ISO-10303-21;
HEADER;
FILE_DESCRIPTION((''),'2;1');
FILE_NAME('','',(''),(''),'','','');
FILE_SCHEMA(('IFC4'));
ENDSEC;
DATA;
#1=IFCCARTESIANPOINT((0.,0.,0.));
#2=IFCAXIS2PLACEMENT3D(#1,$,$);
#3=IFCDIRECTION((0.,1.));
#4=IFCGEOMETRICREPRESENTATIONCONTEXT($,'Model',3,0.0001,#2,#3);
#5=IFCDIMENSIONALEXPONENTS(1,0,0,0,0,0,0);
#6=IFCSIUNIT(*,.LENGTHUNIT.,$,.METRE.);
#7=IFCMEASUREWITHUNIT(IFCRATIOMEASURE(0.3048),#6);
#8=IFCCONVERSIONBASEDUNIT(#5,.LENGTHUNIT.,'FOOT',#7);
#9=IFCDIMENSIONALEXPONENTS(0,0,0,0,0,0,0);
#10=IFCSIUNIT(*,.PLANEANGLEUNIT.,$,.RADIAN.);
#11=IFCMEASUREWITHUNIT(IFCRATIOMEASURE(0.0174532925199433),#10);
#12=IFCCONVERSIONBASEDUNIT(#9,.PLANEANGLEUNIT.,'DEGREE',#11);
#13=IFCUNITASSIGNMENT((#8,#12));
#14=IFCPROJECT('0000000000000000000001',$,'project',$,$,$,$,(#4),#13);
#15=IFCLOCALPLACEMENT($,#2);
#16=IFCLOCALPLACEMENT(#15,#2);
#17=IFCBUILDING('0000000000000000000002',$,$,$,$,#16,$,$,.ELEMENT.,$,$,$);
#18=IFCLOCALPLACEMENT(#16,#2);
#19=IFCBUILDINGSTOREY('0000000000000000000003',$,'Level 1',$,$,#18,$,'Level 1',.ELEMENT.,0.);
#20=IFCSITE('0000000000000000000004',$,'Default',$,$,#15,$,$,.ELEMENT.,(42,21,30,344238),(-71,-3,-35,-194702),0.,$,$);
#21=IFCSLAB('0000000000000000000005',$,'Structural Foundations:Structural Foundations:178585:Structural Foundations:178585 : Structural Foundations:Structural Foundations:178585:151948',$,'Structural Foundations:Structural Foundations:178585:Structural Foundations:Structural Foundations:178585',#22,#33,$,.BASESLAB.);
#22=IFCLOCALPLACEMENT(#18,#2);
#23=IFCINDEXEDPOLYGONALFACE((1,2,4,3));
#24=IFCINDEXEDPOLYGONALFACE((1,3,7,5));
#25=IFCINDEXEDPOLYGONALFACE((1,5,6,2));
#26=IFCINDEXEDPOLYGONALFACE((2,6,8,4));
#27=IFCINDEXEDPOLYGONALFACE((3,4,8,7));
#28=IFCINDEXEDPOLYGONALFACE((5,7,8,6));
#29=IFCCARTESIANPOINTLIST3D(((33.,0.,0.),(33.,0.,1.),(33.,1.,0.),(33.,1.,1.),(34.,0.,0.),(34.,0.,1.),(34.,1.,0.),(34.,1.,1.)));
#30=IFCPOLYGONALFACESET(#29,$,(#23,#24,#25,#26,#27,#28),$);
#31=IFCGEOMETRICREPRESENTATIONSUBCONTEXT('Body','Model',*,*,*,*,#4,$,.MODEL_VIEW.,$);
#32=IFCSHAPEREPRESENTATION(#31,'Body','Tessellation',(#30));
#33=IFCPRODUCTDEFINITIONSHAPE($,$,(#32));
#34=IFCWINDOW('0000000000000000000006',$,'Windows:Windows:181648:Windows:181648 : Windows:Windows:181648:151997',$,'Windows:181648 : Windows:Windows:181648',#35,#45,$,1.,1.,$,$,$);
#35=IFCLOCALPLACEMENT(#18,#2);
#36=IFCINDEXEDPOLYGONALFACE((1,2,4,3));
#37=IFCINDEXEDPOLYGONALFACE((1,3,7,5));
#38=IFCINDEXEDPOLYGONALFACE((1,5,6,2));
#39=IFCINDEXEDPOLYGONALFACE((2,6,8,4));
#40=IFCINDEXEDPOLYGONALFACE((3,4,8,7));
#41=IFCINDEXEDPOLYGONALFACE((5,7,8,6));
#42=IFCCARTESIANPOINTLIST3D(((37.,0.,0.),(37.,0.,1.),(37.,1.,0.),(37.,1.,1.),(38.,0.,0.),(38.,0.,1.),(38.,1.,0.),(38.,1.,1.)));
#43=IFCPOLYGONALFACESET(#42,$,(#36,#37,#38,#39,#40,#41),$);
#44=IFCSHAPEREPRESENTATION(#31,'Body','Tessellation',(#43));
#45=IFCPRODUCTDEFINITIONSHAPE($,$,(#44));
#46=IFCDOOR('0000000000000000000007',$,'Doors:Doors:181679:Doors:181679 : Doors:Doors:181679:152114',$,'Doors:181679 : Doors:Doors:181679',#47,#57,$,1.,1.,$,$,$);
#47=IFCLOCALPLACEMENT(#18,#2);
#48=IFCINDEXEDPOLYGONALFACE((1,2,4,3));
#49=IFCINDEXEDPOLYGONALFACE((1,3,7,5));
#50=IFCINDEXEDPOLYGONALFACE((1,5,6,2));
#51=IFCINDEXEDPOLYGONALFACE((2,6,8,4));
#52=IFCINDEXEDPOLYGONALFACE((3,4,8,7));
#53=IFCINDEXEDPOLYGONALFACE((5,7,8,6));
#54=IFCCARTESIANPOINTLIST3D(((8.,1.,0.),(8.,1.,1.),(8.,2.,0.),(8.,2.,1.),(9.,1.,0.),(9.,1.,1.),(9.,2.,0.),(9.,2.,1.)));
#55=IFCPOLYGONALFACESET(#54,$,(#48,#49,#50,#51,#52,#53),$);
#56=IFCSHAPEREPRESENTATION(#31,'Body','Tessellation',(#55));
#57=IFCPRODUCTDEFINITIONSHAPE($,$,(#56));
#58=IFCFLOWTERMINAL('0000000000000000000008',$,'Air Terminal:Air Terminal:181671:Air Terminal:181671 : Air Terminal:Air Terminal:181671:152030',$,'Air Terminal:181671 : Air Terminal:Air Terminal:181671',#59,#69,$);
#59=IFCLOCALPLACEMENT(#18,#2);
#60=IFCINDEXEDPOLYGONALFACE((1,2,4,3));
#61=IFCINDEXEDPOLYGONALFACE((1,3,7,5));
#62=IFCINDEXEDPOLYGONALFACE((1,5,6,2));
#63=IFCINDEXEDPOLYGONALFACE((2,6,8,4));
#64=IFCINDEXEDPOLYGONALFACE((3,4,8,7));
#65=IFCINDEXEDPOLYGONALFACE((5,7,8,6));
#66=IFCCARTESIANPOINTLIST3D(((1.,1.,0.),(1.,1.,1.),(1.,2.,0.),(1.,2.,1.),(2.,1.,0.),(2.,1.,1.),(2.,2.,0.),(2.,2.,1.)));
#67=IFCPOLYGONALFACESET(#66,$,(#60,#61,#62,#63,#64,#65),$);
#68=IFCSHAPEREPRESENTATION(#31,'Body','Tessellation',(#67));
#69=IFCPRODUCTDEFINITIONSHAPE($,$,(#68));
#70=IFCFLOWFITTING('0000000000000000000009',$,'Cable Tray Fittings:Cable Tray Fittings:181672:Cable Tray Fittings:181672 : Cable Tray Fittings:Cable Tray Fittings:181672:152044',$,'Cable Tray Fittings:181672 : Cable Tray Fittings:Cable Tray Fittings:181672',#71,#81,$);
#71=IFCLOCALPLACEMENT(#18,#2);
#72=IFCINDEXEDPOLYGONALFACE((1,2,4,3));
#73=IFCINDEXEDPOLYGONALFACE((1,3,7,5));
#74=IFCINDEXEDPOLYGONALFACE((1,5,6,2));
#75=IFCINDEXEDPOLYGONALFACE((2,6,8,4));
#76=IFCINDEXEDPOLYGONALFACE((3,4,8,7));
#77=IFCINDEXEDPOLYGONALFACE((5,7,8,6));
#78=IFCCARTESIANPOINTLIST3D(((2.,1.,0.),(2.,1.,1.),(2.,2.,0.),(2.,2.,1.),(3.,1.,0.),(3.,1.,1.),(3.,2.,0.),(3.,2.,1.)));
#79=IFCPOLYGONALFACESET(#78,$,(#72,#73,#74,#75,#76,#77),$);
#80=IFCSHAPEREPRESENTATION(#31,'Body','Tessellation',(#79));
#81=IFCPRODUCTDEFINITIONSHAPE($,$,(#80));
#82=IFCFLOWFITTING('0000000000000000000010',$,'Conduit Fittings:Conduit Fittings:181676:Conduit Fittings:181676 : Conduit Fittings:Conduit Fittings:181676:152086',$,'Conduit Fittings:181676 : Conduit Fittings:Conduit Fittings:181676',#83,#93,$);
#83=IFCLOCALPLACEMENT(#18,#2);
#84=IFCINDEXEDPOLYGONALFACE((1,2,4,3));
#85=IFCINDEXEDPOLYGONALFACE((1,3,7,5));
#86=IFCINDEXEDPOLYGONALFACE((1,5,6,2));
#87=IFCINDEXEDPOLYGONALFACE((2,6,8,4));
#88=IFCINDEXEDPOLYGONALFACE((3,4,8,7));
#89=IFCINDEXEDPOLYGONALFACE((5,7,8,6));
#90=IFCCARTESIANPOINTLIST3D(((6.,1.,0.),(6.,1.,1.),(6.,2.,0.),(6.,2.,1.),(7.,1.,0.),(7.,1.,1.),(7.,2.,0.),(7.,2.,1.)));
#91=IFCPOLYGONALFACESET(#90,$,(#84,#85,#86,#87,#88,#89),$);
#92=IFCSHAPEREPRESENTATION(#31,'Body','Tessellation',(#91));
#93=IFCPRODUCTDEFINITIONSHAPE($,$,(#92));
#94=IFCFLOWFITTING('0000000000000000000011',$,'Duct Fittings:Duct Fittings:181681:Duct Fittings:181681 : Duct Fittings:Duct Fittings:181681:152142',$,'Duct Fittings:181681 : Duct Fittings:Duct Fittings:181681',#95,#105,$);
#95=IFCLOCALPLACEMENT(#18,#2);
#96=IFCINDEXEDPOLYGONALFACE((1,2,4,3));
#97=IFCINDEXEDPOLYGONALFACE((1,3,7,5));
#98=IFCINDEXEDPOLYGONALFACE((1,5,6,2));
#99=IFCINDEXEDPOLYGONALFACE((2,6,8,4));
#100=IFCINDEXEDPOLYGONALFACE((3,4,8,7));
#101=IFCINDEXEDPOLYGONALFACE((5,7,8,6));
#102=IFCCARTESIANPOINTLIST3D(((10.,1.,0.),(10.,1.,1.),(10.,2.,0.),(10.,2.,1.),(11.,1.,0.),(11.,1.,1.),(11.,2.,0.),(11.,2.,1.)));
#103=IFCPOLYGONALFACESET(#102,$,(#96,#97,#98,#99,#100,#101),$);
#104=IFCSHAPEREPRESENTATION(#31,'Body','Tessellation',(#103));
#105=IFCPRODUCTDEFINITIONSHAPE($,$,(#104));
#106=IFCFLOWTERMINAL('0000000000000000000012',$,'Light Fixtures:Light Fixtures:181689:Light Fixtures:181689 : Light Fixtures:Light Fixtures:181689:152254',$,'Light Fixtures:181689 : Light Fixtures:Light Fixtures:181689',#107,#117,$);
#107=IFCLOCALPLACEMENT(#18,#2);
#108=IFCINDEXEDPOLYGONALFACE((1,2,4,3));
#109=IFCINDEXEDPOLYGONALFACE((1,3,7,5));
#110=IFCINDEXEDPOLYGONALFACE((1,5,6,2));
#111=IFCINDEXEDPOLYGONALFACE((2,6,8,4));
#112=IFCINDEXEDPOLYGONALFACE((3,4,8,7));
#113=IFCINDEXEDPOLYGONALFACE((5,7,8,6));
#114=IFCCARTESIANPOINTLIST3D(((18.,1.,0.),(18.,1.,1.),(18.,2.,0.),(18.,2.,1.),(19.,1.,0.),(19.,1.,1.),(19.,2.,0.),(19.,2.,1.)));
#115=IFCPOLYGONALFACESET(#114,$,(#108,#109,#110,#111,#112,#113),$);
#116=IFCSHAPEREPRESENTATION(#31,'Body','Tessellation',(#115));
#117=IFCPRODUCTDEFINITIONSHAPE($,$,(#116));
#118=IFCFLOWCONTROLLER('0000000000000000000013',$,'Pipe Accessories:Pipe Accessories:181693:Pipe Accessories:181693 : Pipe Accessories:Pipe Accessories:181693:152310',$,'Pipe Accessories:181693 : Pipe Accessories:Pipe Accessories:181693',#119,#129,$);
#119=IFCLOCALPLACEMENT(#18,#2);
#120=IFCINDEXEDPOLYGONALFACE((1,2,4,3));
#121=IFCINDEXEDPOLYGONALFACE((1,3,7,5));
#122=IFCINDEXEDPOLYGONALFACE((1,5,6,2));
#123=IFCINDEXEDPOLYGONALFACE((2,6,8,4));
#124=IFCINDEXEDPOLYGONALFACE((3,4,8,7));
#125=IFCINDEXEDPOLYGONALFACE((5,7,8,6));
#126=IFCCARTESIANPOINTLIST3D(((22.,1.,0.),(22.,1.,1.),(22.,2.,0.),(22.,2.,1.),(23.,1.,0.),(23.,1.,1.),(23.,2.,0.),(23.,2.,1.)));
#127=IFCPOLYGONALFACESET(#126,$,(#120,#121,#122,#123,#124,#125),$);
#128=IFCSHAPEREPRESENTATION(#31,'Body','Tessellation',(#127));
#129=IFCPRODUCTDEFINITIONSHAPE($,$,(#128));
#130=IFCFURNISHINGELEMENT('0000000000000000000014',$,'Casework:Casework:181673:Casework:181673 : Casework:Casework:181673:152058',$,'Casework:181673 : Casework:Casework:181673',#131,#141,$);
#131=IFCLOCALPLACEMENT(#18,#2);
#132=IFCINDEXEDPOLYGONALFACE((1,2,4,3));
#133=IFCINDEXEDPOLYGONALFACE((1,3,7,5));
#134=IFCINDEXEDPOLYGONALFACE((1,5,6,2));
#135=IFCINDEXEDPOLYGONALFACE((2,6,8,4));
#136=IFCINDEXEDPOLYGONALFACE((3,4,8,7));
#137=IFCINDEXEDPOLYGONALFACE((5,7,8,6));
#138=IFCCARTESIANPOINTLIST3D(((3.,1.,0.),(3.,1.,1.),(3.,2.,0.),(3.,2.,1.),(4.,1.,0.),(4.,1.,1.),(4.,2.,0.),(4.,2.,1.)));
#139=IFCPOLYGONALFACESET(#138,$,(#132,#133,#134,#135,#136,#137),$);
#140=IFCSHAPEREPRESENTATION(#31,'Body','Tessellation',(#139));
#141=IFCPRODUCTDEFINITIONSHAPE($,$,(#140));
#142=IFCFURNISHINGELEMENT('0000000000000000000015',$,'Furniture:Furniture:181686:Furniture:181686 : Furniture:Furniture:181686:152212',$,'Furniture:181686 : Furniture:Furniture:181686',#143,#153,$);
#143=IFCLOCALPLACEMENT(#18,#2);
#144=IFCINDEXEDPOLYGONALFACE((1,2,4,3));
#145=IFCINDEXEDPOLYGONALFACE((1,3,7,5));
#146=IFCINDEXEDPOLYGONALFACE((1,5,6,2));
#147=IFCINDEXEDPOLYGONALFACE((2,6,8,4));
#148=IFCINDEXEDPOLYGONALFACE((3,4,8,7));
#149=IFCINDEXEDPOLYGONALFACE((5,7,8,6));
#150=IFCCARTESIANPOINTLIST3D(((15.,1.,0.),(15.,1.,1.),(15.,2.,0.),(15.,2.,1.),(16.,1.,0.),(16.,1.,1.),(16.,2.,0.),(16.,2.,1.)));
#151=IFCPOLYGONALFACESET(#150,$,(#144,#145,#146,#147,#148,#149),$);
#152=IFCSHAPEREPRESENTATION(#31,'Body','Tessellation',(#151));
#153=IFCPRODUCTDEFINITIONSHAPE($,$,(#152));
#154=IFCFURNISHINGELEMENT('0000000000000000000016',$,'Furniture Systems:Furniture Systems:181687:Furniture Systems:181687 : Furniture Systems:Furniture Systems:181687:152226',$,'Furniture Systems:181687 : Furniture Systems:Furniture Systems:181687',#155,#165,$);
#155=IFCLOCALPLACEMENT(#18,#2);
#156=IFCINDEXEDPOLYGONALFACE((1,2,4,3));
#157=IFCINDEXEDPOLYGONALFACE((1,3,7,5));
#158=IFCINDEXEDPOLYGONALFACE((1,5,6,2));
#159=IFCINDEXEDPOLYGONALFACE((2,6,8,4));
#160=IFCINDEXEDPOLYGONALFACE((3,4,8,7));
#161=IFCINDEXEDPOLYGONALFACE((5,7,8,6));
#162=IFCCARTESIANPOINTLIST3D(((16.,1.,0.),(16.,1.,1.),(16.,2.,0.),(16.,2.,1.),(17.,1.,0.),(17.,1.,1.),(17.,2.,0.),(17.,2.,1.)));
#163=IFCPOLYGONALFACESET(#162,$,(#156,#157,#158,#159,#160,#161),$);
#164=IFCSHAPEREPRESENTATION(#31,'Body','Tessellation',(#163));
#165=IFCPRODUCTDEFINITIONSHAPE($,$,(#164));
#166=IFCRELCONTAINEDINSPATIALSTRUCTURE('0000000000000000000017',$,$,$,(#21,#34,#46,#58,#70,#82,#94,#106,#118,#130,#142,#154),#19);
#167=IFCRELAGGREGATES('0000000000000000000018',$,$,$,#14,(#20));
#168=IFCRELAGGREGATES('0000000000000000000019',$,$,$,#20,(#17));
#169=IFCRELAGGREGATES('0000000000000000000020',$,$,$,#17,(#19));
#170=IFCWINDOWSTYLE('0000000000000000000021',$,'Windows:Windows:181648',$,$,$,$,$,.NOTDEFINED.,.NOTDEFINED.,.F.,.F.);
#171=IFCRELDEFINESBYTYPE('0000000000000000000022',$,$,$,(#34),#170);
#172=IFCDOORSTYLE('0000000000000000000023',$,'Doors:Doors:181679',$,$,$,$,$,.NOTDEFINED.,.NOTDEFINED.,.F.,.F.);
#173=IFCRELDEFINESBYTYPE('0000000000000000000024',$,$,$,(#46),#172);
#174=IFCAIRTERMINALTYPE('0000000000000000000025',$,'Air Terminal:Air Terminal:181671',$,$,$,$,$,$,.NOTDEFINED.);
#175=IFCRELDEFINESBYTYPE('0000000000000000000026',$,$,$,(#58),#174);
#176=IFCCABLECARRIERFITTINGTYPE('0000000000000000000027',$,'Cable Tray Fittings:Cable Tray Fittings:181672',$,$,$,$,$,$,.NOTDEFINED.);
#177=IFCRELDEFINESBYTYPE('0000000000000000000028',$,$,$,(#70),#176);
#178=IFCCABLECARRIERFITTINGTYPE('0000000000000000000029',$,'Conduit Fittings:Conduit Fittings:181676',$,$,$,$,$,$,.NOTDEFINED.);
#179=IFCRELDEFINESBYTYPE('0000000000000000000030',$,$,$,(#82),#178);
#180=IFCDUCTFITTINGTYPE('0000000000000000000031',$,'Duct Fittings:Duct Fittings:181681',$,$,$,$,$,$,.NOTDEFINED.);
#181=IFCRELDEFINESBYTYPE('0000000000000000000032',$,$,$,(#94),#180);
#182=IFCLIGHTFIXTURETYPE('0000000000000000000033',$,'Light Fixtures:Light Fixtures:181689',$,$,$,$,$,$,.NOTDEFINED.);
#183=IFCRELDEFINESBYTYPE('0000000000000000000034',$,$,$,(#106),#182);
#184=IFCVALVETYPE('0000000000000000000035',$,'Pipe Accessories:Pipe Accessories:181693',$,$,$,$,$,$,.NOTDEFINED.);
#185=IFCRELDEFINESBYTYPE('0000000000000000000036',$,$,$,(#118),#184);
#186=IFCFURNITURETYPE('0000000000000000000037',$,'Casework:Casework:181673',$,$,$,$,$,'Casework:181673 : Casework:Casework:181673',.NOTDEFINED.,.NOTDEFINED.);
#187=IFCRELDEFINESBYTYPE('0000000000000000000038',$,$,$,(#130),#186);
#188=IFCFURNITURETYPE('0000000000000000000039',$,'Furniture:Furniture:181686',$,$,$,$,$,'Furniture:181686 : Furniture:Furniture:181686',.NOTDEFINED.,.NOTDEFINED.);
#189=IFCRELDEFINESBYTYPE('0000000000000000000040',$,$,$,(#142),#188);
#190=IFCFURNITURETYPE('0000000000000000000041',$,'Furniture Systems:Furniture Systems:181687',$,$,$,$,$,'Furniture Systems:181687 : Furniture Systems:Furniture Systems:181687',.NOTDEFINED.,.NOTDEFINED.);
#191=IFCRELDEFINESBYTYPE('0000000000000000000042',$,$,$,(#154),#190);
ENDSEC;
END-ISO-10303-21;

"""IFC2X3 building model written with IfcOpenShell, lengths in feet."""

from ifc_helpers import new_model, entity, si_unit, converted_unit, direction, frame, frame_2d, origin, origin_2d_with_axis, place, context, subcontext, project, spatial, rectangle, extrude, source, transform, mapped, type_object, type_shapes, element, save


model = new_model("IFC2X3")

# Units and contexts
model_context = context("Model", 3, precision=0.0001, world=origin(), true_north=direction((0.0, 1.0)))
body_context = subcontext(model_context, "Body", "Model", "MODEL_VIEW")
ifc_project = project(units=[converted_unit("LENGTHUNIT", "FOOT", entity("IfcRatioMeasure", 0.3048), si_unit("LENGTHUNIT", "METRE"), dimensions=[1, 0, 0, 0, 0, 0, 0]), converted_unit("PLANEANGLEUNIT", "DEGREE", entity("IfcRatioMeasure", 0.0174532925199433), si_unit("PLANEANGLEUNIT", "RADIAN"), dimensions=[0, 0, 0, 0, 0, 0, 0])], contexts=[model_context])

# Site, building, storey
site_placement = place(None, origin())
site = spatial("IfcSite", under=ifc_project, at=site_placement, Name="Default", CompositionType="ELEMENT", RefLatitude=(42, 21, 30, 344238), RefLongitude=(-71, -3, -35, -194702), RefElevation=0.0)
building_placement = place(site_placement, origin())
building = spatial("IfcBuilding", under=site, at=building_placement, CompositionType="ELEMENT")
storey_placement = place(building_placement, origin())
storey = spatial("IfcBuildingStorey", under=building, at=storey_placement, Name="Level 1", LongName="Level 1", CompositionType="ELEMENT", Elevation=0.0)

# Slab
slab_placement = place(storey_placement, origin())
element("IfcSlab", 1, at=slab_placement, inside=storey, Name="Structural Foundations:Structural Foundations:178585:Structural Foundations:178585 : Structural Foundations:Structural Foundations:178585:151948", ObjectType="Structural Foundations:Structural Foundations:178585:Structural Foundations:Structural Foundations:178585", PredefinedType="BASESLAB", context=body_context, shape_type="SweptSolid", body=[
    extrude(rectangle(XDim=1.0, YDim=1.0, at=origin_2d_with_axis()), frame((33.5, 0.5, 0.0), z_axis=(0.0, 0.0, 1.0), x_axis=(-1.0, 0.0, 0.0)), (0.0, 0.0, 1.0), 1.0),
])

# Window
window_style = type_object("IfcWindowStyle", Name="Windows:Windows:181648", ConstructionType="NOTDEFINED", OperationType="NOTDEFINED", ParameterTakesPrecedence=False, Sizeable=False)
shared_shape_1 = source(origin(), body_context, "Body", "SweptSolid", [
    extrude(rectangle(XDim=1.0, YDim=1.0, at=origin_2d_with_axis()), frame((37.5, 0.5, 0.0), z_axis=(0.0, 0.0, 1.0), x_axis=(-1.0, 0.0, 0.0)), (0.0, 0.0, 1.0), 1.0),
])
type_shapes(window_style, [shared_shape_1])
window_placement = place(storey_placement, origin())
element("IfcWindow", 2, at=window_placement, inside=storey, type_object=window_style, Name="Windows:Windows:181648:Windows:181648 : Windows:Windows:181648:151997", ObjectType="Windows:181648 : Windows:Windows:181648", OverallHeight=1.0, OverallWidth=1.0, context=body_context, shape_type="MappedRepresentation", body=[
    mapped(shared_shape_1, transform((0.0, 0.0, 0.0), scale=1.0)),
])

# Door
door_style = type_object("IfcDoorStyle", Name="Doors:Doors:181679", ConstructionType="NOTDEFINED", OperationType="NOTDEFINED", ParameterTakesPrecedence=False, Sizeable=False)
shared_shape_2 = source(origin(), body_context, "Body", "SweptSolid", [
    extrude(rectangle(XDim=1.0, YDim=1.0, at=frame_2d((0.0, 0.0), x_axis=(1.0, 0.0))), frame((8.5, 1.5, 0.0), z_axis=(0.0, 0.0, 1.0), x_axis=(-1.0, 0.0, 0.0)), (0.0, 0.0, 1.0), 1.0),
])
type_shapes(door_style, [shared_shape_2])
door_placement = place(storey_placement, origin())
element("IfcDoor", 3, at=door_placement, inside=storey, type_object=door_style, Name="Doors:Doors:181679:Doors:181679 : Doors:Doors:181679:152114", ObjectType="Doors:181679 : Doors:Doors:181679", OverallHeight=1.0, OverallWidth=1.0, context=body_context, shape_type="MappedRepresentation", body=[
    mapped(shared_shape_2, transform((0.0, 0.0, 0.0), scale=1.0)),
])

# Flow terminal
air_terminal_type = type_object("IfcAirTerminalType", Name="Air Terminal:Air Terminal:181671", PredefinedType="NOTDEFINED")
shared_shape_3 = source(origin(), body_context, "Body", "SweptSolid", [
    extrude(rectangle(XDim=1.0, YDim=1.0, at=frame_2d((0.0, 0.0), x_axis=(1.0, 0.0))), frame((1.5, 1.5, 0.0), z_axis=(0.0, 0.0, 1.0), x_axis=(-1.0, 0.0, 0.0)), (0.0, 0.0, 1.0), 1.0),
])
type_shapes(air_terminal_type, [shared_shape_3])
flow_terminal_1_placement = place(storey_placement, origin())
element("IfcFlowTerminal", 4, at=flow_terminal_1_placement, inside=storey, type_object=air_terminal_type, Name="Air Terminal:Air Terminal:181671:Air Terminal:181671 : Air Terminal:Air Terminal:181671:152030", ObjectType="Air Terminal:181671 : Air Terminal:Air Terminal:181671", context=body_context, shape_type="MappedRepresentation", body=[
    mapped(shared_shape_3, transform((0.0, 0.0, 0.0), scale=1.0)),
])

# Flow fittings
cable_carrier_fitting_type_1 = type_object("IfcCableCarrierFittingType", Name="Cable Tray Fittings:Cable Tray Fittings:181672", PredefinedType="NOTDEFINED")
shared_shape_4 = source(origin(), body_context, "Body", "SweptSolid", [
    extrude(rectangle(XDim=1.0, YDim=1.0, at=frame_2d((0.0, 0.0), x_axis=(1.0, 0.0))), frame((2.5, 1.5, 0.0), z_axis=(0.0, 0.0, 1.0), x_axis=(-1.0, 0.0, 0.0)), (0.0, 0.0, 1.0), 1.0),
])
type_shapes(cable_carrier_fitting_type_1, [shared_shape_4])
flow_fitting_1_placement = place(storey_placement, origin())
element("IfcFlowFitting", 5, at=flow_fitting_1_placement, inside=storey, type_object=cable_carrier_fitting_type_1, Name="Cable Tray Fittings:Cable Tray Fittings:181672:Cable Tray Fittings:181672 : Cable Tray Fittings:Cable Tray Fittings:181672:152044", ObjectType="Cable Tray Fittings:181672 : Cable Tray Fittings:Cable Tray Fittings:181672", context=body_context, shape_type="MappedRepresentation", body=[
    mapped(shared_shape_4, transform((0.0, 0.0, 0.0), scale=1.0)),
])
cable_carrier_fitting_type_2 = type_object("IfcCableCarrierFittingType", Name="Conduit Fittings:Conduit Fittings:181676", PredefinedType="NOTDEFINED")
shared_shape_5 = source(origin(), body_context, "Body", "SweptSolid", [
    extrude(rectangle(XDim=1.0, YDim=1.0, at=frame_2d((0.0, 0.0), x_axis=(1.0, 0.0))), frame((6.5, 1.5, 0.0), z_axis=(0.0, 0.0, 1.0), x_axis=(-1.0, 0.0, 0.0)), (0.0, 0.0, 1.0), 1.0),
])
type_shapes(cable_carrier_fitting_type_2, [shared_shape_5])
flow_fitting_2_placement = place(storey_placement, origin())
element("IfcFlowFitting", 6, at=flow_fitting_2_placement, inside=storey, type_object=cable_carrier_fitting_type_2, Name="Conduit Fittings:Conduit Fittings:181676:Conduit Fittings:181676 : Conduit Fittings:Conduit Fittings:181676:152086", ObjectType="Conduit Fittings:181676 : Conduit Fittings:Conduit Fittings:181676", context=body_context, shape_type="MappedRepresentation", body=[
    mapped(shared_shape_5, transform((0.0, 0.0, 0.0), scale=1.0)),
])
duct_fitting_type = type_object("IfcDuctFittingType", Name="Duct Fittings:Duct Fittings:181681", PredefinedType="NOTDEFINED")
shared_shape_6 = source(origin(), body_context, "Body", "SweptSolid", [
    extrude(rectangle(XDim=1.0, YDim=1.0, at=frame_2d((0.0, 0.0), x_axis=(1.0, 0.0))), frame((10.5, 1.5, 0.0), z_axis=(0.0, 0.0, 1.0), x_axis=(-1.0, 0.0, 0.0)), (0.0, 0.0, 1.0), 1.0),
])
type_shapes(duct_fitting_type, [shared_shape_6])
flow_fitting_3_placement = place(storey_placement, origin())
element("IfcFlowFitting", 7, at=flow_fitting_3_placement, inside=storey, type_object=duct_fitting_type, Name="Duct Fittings:Duct Fittings:181681:Duct Fittings:181681 : Duct Fittings:Duct Fittings:181681:152142", ObjectType="Duct Fittings:181681 : Duct Fittings:Duct Fittings:181681", context=body_context, shape_type="MappedRepresentation", body=[
    mapped(shared_shape_6, transform((0.0, 0.0, 0.0), scale=1.0)),
])

# Flow terminal
light_fixture_type = type_object("IfcLightFixtureType", Name="Light Fixtures:Light Fixtures:181689", PredefinedType="NOTDEFINED")
shared_shape_7 = source(origin(), body_context, "Body", "SweptSolid", [
    extrude(rectangle(XDim=1.0, YDim=1.0, at=frame_2d((0.0, 0.0), x_axis=(1.0, 0.0))), frame((18.5, 1.5, 0.0), z_axis=(0.0, 0.0, 1.0), x_axis=(-1.0, 0.0, 0.0)), (0.0, 0.0, 1.0), 1.0),
])
type_shapes(light_fixture_type, [shared_shape_7])
flow_terminal_2_placement = place(storey_placement, origin())
element("IfcFlowTerminal", 8, at=flow_terminal_2_placement, inside=storey, type_object=light_fixture_type, Name="Light Fixtures:Light Fixtures:181689:Light Fixtures:181689 : Light Fixtures:Light Fixtures:181689:152254", ObjectType="Light Fixtures:181689 : Light Fixtures:Light Fixtures:181689", context=body_context, shape_type="MappedRepresentation", body=[
    mapped(shared_shape_7, transform((0.0, 0.0, 0.0), scale=1.0)),
])

# Flow controller
valve_type = type_object("IfcValveType", Name="Pipe Accessories:Pipe Accessories:181693", PredefinedType="NOTDEFINED")
shared_shape_8 = source(origin(), body_context, "Body", "SweptSolid", [
    extrude(rectangle(XDim=1.0, YDim=1.0, at=frame_2d((0.0, 0.0), x_axis=(1.0, 0.0))), frame((22.5, 1.5, 0.0), z_axis=(0.0, 0.0, 1.0), x_axis=(-1.0, 0.0, 0.0)), (0.0, 0.0, 1.0), 1.0),
])
type_shapes(valve_type, [shared_shape_8])
flow_controller_placement = place(storey_placement, origin())
element("IfcFlowController", 9, at=flow_controller_placement, inside=storey, type_object=valve_type, Name="Pipe Accessories:Pipe Accessories:181693:Pipe Accessories:181693 : Pipe Accessories:Pipe Accessories:181693:152310", ObjectType="Pipe Accessories:181693 : Pipe Accessories:Pipe Accessories:181693", context=body_context, shape_type="MappedRepresentation", body=[
    mapped(shared_shape_8, transform((0.0, 0.0, 0.0), scale=1.0)),
])

# Furnishing elements
furniture_type_1 = type_object("IfcFurnitureType", Name="Casework:Casework:181673", ElementType="Casework:181673 : Casework:Casework:181673")
shared_shape_9 = source(origin(), body_context, "Body", "SweptSolid", [
    extrude(rectangle(XDim=1.0, YDim=1.0, at=frame_2d((0.0, 0.0), x_axis=(1.0, 0.0))), frame((3.5, 1.5, 0.0), z_axis=(0.0, 0.0, 1.0), x_axis=(-1.0, 0.0, 0.0)), (0.0, 0.0, 1.0), 1.0),
])
type_shapes(furniture_type_1, [shared_shape_9])
furnishing_1_placement = place(storey_placement, origin())
element("IfcFurnishingElement", 10, at=furnishing_1_placement, inside=storey, type_object=furniture_type_1, Name="Casework:Casework:181673:Casework:181673 : Casework:Casework:181673:152058", ObjectType="Casework:181673 : Casework:Casework:181673", context=body_context, shape_type="MappedRepresentation", body=[
    mapped(shared_shape_9, transform((0.0, 0.0, 0.0), scale=1.0)),
])
furniture_type_2 = type_object("IfcFurnitureType", Name="Furniture:Furniture:181686", ElementType="Furniture:181686 : Furniture:Furniture:181686")
shared_shape_10 = source(origin(), body_context, "Body", "SweptSolid", [
    extrude(rectangle(XDim=1.0, YDim=1.0, at=frame_2d((0.0, 0.0), x_axis=(1.0, 0.0))), frame((15.5, 1.5, 0.0), z_axis=(0.0, 0.0, 1.0), x_axis=(-1.0, 0.0, 0.0)), (0.0, 0.0, 1.0), 1.0),
])
type_shapes(furniture_type_2, [shared_shape_10])
furnishing_2_placement = place(storey_placement, origin())
element("IfcFurnishingElement", 11, at=furnishing_2_placement, inside=storey, type_object=furniture_type_2, Name="Furniture:Furniture:181686:Furniture:181686 : Furniture:Furniture:181686:152212", ObjectType="Furniture:181686 : Furniture:Furniture:181686", context=body_context, shape_type="MappedRepresentation", body=[
    mapped(shared_shape_10, transform((0.0, 0.0, 0.0), scale=1.0)),
])
furniture_type_3 = type_object("IfcFurnitureType", Name="Furniture Systems:Furniture Systems:181687", ElementType="Furniture Systems:181687 : Furniture Systems:Furniture Systems:181687")
shared_shape_11 = source(origin(), body_context, "Body", "SweptSolid", [
    extrude(rectangle(XDim=1.0, YDim=1.0, at=frame_2d((0.0, 0.0), x_axis=(1.0, 0.0))), frame((16.5, 1.5, 0.0), z_axis=(0.0, 0.0, 1.0), x_axis=(-1.0, 0.0, 0.0)), (0.0, 0.0, 1.0), 1.0),
])
type_shapes(furniture_type_3, [shared_shape_11])
furnishing_3_placement = place(storey_placement, origin())
element("IfcFurnishingElement", 12, at=furnishing_3_placement, inside=storey, type_object=furniture_type_3, Name="Furniture Systems:Furniture Systems:181687:Furniture Systems:181687 : Furniture Systems:Furniture Systems:181687:152226", ObjectType="Furniture Systems:181687 : Furniture Systems:Furniture Systems:181687", context=body_context, shape_type="MappedRepresentation", body=[
    mapped(shared_shape_11, transform((0.0, 0.0, 0.0), scale=1.0)),
])

save(model, "model.ifc")
